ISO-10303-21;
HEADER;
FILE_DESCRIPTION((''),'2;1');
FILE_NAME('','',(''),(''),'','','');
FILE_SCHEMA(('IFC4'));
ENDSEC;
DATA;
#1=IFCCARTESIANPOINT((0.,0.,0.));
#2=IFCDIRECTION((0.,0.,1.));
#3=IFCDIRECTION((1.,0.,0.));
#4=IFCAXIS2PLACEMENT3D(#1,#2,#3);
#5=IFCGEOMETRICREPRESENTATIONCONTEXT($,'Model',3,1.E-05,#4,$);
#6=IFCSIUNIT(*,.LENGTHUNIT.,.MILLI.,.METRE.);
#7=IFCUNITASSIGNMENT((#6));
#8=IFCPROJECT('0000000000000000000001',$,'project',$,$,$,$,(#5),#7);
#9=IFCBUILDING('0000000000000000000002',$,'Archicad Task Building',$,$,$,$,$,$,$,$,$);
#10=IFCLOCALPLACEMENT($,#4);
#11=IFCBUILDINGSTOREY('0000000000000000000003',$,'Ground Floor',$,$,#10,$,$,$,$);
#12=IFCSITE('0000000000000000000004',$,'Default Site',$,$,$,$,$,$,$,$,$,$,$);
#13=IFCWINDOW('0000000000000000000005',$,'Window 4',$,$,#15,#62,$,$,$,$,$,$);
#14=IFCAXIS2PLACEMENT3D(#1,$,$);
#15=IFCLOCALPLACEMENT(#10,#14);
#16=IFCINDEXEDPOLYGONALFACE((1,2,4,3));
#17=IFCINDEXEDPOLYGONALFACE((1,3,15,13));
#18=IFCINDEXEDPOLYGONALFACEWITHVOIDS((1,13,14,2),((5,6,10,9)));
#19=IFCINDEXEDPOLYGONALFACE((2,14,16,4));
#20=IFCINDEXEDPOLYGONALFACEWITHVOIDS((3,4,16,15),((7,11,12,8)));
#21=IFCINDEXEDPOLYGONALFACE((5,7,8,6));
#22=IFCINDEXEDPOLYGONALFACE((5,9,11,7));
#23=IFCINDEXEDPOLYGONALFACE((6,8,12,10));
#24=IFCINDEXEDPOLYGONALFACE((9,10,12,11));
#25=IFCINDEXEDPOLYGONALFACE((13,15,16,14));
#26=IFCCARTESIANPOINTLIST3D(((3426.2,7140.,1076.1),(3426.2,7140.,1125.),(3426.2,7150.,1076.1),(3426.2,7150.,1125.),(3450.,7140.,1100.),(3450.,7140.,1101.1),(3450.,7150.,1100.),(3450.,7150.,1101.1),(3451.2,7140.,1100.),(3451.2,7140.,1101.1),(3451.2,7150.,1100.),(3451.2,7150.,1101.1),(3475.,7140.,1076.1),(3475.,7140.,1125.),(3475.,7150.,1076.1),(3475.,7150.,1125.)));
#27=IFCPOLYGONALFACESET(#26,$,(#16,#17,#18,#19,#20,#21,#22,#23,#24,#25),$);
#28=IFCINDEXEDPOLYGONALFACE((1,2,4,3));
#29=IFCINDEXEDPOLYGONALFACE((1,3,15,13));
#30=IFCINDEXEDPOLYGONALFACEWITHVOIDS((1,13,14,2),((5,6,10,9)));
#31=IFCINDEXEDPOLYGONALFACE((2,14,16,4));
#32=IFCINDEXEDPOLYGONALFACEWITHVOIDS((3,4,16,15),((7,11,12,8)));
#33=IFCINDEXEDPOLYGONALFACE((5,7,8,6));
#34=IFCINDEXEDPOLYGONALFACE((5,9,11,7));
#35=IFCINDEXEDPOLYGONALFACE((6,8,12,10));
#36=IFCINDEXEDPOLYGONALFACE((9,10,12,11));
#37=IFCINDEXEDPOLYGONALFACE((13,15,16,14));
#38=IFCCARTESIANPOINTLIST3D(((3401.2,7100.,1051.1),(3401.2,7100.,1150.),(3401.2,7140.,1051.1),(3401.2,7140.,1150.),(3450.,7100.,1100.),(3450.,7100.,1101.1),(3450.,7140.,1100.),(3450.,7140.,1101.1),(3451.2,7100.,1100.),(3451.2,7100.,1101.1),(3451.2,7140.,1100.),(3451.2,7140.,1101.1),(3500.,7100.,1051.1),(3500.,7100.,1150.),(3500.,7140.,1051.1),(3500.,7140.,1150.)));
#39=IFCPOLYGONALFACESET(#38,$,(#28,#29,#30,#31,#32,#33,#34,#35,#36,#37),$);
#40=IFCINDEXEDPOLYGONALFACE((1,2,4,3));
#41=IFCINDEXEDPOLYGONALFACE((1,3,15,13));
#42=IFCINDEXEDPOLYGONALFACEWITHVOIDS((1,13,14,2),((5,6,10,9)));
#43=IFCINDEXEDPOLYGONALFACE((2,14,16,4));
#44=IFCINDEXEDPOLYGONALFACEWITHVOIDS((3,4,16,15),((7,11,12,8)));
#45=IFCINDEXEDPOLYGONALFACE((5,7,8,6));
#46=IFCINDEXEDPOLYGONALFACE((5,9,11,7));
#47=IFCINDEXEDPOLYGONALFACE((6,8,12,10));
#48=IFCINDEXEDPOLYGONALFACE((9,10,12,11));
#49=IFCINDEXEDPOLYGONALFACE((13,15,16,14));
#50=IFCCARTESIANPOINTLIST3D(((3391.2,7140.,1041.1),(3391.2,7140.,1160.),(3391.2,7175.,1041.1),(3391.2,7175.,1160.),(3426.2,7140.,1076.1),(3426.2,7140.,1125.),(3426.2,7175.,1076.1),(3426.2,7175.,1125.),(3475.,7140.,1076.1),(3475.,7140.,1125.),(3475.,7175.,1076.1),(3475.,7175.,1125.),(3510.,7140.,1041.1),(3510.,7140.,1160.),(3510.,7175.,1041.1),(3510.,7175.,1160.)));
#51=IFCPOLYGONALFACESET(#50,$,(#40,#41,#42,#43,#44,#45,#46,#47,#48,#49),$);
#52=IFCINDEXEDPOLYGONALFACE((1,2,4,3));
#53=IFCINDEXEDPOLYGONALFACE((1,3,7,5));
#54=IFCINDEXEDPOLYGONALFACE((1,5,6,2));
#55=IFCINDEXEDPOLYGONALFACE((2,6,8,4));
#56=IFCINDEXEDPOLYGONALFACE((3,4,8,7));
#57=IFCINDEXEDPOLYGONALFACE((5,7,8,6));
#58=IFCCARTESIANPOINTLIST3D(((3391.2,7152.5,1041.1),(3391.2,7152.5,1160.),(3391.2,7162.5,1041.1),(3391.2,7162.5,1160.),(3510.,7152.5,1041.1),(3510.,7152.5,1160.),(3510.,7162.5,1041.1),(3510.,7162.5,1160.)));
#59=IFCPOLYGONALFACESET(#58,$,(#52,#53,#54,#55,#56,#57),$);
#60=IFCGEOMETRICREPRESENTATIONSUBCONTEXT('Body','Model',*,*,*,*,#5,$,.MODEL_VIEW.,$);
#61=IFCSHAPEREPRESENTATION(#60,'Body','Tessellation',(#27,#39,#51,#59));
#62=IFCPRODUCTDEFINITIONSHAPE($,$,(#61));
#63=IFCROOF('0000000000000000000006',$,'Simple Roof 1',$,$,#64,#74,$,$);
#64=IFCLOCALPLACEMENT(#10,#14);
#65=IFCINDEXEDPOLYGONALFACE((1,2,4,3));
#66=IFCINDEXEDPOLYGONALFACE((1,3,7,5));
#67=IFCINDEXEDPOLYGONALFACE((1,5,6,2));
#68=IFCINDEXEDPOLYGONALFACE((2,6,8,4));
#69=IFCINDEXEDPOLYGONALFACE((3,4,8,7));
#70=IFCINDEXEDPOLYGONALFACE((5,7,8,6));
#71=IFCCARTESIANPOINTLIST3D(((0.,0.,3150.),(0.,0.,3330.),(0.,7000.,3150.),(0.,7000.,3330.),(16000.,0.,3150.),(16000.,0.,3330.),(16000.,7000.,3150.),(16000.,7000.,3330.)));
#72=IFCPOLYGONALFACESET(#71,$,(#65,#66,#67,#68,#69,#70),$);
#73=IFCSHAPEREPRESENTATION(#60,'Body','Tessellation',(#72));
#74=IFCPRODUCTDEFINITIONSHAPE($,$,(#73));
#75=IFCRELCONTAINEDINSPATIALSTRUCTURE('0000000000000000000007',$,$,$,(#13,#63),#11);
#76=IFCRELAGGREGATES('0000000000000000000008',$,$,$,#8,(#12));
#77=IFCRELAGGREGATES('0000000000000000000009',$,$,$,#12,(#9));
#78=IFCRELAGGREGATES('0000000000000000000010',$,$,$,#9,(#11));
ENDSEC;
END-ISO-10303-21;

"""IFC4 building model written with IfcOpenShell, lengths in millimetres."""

from ifc_helpers import new_model, si_unit, frame, origin_with_axes, place, context, subcontext, project, spatial, line, indexed_curve, outline, extrude, element, save


model = new_model("IFC4")

# Units and contexts
model_context = context("Model", 3, precision=1e-05, world=origin_with_axes())
body_context = subcontext(model_context, "Body", "Model", "MODEL_VIEW")
ifc_project = project(units=[si_unit("LENGTHUNIT", "METRE", prefix="MILLI")], contexts=[model_context])

# Site, building, storey
site = spatial("IfcSite", under=ifc_project, Name="Default Site")
building = spatial("IfcBuilding", under=site, Name="Archicad Task Building")
storey_placement = place(None, origin_with_axes())
storey = spatial("IfcBuildingStorey", under=building, at=storey_placement, Name="Ground Floor")

# Window
for number, where, z_axis, x_axis, name in (
    (1, (3450.0, 7050.0, 1100.0), (0.0, 0.0, 1.0), (1.0, 0.0, 0.0), "Window 4"),
):
    element("IfcWindow", number, at=place(storey_placement, frame(where, z_axis=z_axis, x_axis=x_axis)), inside=storey, Name=name, context=body_context, shape_type="SweptSolid", body=[
        extrude(outline(indexed_curve([(0.0, 0.0), (1.2, 0.0), (1.2, 1.1), (0.0, 1.1)], segments=[line(1, 2, 3, 4, 1)]), holes=[indexed_curve([(25.0, 25.0), (-23.8, 25.0), (-23.8, -23.9), (25.0, -23.9)], segments=[line(1, 2, 3, 4, 1)])]), frame((0.0, 90.0, 0.0), z_axis=(0.0, -1.0, 0.0), x_axis=(1.0, 0.0, 0.0)), (0.0, 0.0, -1.0), 10.0),
        extrude(outline(indexed_curve([(0.0, 0.0), (1.2, 0.0), (1.2, 1.1), (0.0, 1.1)], segments=[line(1, 2, 3, 4, 1)]), holes=[indexed_curve([(50.0, 50.0), (-48.8, 50.0), (-48.8, -48.9), (50.0, -48.9)], segments=[line(1, 2, 3, 4, 1)])]), frame((0.0, 50.0, 0.0), z_axis=(0.0, -1.0, 0.0), x_axis=(1.0, 0.0, 0.0)), (0.0, 0.0, -1.0), 40.0),
        extrude(outline(indexed_curve([(0.0, 0.0), (-48.8, 0.0), (-48.8, -48.9), (0.0, -48.9)], segments=[line(1, 2, 3, 4, 1)]), holes=[indexed_curve([(35.0, 35.0), (-83.8, 35.0), (-83.8, -83.9), (35.0, -83.9)], segments=[line(1, 2, 3, 4, 1)])]), frame((25.0, 90.0, 25.0), z_axis=(0.0, -1.0, 0.0), x_axis=(1.0, 0.0, 0.0)), (0.0, 0.0, -1.0), 35.0),
        extrude(outline(indexed_curve([(35.0, 35.0), (-83.8, 35.0), (-83.8, -83.9), (35.0, -83.9)], segments=[line(1, 2, 3, 4, 1)])), frame((25.0, 102.5, 25.0), z_axis=(0.0, -1.0, 0.0), x_axis=(1.0, 0.0, 0.0)), (0.0, 0.0, -1.0), 10.0),
    ])

# Roof
roof_placement = place(storey_placement, frame((0.0, 0.0, 3150.0), z_axis=(0.0, 0.0, 1.0), x_axis=(1.0, 0.0, 0.0)))
element("IfcRoof", 2, at=roof_placement, inside=storey, Name="Simple Roof 1", context=body_context, shape_type="SweptSolid", body=[
    extrude(outline(indexed_curve([(0.0, 0.0), (16000.0, 0.0), (16000.0, 7000.0), (0.0, 7000.0), (0.0, 0.0)])), None, (0.0, 0.0, 1.0), 180.0),
])

save(model, "model.ifc")
